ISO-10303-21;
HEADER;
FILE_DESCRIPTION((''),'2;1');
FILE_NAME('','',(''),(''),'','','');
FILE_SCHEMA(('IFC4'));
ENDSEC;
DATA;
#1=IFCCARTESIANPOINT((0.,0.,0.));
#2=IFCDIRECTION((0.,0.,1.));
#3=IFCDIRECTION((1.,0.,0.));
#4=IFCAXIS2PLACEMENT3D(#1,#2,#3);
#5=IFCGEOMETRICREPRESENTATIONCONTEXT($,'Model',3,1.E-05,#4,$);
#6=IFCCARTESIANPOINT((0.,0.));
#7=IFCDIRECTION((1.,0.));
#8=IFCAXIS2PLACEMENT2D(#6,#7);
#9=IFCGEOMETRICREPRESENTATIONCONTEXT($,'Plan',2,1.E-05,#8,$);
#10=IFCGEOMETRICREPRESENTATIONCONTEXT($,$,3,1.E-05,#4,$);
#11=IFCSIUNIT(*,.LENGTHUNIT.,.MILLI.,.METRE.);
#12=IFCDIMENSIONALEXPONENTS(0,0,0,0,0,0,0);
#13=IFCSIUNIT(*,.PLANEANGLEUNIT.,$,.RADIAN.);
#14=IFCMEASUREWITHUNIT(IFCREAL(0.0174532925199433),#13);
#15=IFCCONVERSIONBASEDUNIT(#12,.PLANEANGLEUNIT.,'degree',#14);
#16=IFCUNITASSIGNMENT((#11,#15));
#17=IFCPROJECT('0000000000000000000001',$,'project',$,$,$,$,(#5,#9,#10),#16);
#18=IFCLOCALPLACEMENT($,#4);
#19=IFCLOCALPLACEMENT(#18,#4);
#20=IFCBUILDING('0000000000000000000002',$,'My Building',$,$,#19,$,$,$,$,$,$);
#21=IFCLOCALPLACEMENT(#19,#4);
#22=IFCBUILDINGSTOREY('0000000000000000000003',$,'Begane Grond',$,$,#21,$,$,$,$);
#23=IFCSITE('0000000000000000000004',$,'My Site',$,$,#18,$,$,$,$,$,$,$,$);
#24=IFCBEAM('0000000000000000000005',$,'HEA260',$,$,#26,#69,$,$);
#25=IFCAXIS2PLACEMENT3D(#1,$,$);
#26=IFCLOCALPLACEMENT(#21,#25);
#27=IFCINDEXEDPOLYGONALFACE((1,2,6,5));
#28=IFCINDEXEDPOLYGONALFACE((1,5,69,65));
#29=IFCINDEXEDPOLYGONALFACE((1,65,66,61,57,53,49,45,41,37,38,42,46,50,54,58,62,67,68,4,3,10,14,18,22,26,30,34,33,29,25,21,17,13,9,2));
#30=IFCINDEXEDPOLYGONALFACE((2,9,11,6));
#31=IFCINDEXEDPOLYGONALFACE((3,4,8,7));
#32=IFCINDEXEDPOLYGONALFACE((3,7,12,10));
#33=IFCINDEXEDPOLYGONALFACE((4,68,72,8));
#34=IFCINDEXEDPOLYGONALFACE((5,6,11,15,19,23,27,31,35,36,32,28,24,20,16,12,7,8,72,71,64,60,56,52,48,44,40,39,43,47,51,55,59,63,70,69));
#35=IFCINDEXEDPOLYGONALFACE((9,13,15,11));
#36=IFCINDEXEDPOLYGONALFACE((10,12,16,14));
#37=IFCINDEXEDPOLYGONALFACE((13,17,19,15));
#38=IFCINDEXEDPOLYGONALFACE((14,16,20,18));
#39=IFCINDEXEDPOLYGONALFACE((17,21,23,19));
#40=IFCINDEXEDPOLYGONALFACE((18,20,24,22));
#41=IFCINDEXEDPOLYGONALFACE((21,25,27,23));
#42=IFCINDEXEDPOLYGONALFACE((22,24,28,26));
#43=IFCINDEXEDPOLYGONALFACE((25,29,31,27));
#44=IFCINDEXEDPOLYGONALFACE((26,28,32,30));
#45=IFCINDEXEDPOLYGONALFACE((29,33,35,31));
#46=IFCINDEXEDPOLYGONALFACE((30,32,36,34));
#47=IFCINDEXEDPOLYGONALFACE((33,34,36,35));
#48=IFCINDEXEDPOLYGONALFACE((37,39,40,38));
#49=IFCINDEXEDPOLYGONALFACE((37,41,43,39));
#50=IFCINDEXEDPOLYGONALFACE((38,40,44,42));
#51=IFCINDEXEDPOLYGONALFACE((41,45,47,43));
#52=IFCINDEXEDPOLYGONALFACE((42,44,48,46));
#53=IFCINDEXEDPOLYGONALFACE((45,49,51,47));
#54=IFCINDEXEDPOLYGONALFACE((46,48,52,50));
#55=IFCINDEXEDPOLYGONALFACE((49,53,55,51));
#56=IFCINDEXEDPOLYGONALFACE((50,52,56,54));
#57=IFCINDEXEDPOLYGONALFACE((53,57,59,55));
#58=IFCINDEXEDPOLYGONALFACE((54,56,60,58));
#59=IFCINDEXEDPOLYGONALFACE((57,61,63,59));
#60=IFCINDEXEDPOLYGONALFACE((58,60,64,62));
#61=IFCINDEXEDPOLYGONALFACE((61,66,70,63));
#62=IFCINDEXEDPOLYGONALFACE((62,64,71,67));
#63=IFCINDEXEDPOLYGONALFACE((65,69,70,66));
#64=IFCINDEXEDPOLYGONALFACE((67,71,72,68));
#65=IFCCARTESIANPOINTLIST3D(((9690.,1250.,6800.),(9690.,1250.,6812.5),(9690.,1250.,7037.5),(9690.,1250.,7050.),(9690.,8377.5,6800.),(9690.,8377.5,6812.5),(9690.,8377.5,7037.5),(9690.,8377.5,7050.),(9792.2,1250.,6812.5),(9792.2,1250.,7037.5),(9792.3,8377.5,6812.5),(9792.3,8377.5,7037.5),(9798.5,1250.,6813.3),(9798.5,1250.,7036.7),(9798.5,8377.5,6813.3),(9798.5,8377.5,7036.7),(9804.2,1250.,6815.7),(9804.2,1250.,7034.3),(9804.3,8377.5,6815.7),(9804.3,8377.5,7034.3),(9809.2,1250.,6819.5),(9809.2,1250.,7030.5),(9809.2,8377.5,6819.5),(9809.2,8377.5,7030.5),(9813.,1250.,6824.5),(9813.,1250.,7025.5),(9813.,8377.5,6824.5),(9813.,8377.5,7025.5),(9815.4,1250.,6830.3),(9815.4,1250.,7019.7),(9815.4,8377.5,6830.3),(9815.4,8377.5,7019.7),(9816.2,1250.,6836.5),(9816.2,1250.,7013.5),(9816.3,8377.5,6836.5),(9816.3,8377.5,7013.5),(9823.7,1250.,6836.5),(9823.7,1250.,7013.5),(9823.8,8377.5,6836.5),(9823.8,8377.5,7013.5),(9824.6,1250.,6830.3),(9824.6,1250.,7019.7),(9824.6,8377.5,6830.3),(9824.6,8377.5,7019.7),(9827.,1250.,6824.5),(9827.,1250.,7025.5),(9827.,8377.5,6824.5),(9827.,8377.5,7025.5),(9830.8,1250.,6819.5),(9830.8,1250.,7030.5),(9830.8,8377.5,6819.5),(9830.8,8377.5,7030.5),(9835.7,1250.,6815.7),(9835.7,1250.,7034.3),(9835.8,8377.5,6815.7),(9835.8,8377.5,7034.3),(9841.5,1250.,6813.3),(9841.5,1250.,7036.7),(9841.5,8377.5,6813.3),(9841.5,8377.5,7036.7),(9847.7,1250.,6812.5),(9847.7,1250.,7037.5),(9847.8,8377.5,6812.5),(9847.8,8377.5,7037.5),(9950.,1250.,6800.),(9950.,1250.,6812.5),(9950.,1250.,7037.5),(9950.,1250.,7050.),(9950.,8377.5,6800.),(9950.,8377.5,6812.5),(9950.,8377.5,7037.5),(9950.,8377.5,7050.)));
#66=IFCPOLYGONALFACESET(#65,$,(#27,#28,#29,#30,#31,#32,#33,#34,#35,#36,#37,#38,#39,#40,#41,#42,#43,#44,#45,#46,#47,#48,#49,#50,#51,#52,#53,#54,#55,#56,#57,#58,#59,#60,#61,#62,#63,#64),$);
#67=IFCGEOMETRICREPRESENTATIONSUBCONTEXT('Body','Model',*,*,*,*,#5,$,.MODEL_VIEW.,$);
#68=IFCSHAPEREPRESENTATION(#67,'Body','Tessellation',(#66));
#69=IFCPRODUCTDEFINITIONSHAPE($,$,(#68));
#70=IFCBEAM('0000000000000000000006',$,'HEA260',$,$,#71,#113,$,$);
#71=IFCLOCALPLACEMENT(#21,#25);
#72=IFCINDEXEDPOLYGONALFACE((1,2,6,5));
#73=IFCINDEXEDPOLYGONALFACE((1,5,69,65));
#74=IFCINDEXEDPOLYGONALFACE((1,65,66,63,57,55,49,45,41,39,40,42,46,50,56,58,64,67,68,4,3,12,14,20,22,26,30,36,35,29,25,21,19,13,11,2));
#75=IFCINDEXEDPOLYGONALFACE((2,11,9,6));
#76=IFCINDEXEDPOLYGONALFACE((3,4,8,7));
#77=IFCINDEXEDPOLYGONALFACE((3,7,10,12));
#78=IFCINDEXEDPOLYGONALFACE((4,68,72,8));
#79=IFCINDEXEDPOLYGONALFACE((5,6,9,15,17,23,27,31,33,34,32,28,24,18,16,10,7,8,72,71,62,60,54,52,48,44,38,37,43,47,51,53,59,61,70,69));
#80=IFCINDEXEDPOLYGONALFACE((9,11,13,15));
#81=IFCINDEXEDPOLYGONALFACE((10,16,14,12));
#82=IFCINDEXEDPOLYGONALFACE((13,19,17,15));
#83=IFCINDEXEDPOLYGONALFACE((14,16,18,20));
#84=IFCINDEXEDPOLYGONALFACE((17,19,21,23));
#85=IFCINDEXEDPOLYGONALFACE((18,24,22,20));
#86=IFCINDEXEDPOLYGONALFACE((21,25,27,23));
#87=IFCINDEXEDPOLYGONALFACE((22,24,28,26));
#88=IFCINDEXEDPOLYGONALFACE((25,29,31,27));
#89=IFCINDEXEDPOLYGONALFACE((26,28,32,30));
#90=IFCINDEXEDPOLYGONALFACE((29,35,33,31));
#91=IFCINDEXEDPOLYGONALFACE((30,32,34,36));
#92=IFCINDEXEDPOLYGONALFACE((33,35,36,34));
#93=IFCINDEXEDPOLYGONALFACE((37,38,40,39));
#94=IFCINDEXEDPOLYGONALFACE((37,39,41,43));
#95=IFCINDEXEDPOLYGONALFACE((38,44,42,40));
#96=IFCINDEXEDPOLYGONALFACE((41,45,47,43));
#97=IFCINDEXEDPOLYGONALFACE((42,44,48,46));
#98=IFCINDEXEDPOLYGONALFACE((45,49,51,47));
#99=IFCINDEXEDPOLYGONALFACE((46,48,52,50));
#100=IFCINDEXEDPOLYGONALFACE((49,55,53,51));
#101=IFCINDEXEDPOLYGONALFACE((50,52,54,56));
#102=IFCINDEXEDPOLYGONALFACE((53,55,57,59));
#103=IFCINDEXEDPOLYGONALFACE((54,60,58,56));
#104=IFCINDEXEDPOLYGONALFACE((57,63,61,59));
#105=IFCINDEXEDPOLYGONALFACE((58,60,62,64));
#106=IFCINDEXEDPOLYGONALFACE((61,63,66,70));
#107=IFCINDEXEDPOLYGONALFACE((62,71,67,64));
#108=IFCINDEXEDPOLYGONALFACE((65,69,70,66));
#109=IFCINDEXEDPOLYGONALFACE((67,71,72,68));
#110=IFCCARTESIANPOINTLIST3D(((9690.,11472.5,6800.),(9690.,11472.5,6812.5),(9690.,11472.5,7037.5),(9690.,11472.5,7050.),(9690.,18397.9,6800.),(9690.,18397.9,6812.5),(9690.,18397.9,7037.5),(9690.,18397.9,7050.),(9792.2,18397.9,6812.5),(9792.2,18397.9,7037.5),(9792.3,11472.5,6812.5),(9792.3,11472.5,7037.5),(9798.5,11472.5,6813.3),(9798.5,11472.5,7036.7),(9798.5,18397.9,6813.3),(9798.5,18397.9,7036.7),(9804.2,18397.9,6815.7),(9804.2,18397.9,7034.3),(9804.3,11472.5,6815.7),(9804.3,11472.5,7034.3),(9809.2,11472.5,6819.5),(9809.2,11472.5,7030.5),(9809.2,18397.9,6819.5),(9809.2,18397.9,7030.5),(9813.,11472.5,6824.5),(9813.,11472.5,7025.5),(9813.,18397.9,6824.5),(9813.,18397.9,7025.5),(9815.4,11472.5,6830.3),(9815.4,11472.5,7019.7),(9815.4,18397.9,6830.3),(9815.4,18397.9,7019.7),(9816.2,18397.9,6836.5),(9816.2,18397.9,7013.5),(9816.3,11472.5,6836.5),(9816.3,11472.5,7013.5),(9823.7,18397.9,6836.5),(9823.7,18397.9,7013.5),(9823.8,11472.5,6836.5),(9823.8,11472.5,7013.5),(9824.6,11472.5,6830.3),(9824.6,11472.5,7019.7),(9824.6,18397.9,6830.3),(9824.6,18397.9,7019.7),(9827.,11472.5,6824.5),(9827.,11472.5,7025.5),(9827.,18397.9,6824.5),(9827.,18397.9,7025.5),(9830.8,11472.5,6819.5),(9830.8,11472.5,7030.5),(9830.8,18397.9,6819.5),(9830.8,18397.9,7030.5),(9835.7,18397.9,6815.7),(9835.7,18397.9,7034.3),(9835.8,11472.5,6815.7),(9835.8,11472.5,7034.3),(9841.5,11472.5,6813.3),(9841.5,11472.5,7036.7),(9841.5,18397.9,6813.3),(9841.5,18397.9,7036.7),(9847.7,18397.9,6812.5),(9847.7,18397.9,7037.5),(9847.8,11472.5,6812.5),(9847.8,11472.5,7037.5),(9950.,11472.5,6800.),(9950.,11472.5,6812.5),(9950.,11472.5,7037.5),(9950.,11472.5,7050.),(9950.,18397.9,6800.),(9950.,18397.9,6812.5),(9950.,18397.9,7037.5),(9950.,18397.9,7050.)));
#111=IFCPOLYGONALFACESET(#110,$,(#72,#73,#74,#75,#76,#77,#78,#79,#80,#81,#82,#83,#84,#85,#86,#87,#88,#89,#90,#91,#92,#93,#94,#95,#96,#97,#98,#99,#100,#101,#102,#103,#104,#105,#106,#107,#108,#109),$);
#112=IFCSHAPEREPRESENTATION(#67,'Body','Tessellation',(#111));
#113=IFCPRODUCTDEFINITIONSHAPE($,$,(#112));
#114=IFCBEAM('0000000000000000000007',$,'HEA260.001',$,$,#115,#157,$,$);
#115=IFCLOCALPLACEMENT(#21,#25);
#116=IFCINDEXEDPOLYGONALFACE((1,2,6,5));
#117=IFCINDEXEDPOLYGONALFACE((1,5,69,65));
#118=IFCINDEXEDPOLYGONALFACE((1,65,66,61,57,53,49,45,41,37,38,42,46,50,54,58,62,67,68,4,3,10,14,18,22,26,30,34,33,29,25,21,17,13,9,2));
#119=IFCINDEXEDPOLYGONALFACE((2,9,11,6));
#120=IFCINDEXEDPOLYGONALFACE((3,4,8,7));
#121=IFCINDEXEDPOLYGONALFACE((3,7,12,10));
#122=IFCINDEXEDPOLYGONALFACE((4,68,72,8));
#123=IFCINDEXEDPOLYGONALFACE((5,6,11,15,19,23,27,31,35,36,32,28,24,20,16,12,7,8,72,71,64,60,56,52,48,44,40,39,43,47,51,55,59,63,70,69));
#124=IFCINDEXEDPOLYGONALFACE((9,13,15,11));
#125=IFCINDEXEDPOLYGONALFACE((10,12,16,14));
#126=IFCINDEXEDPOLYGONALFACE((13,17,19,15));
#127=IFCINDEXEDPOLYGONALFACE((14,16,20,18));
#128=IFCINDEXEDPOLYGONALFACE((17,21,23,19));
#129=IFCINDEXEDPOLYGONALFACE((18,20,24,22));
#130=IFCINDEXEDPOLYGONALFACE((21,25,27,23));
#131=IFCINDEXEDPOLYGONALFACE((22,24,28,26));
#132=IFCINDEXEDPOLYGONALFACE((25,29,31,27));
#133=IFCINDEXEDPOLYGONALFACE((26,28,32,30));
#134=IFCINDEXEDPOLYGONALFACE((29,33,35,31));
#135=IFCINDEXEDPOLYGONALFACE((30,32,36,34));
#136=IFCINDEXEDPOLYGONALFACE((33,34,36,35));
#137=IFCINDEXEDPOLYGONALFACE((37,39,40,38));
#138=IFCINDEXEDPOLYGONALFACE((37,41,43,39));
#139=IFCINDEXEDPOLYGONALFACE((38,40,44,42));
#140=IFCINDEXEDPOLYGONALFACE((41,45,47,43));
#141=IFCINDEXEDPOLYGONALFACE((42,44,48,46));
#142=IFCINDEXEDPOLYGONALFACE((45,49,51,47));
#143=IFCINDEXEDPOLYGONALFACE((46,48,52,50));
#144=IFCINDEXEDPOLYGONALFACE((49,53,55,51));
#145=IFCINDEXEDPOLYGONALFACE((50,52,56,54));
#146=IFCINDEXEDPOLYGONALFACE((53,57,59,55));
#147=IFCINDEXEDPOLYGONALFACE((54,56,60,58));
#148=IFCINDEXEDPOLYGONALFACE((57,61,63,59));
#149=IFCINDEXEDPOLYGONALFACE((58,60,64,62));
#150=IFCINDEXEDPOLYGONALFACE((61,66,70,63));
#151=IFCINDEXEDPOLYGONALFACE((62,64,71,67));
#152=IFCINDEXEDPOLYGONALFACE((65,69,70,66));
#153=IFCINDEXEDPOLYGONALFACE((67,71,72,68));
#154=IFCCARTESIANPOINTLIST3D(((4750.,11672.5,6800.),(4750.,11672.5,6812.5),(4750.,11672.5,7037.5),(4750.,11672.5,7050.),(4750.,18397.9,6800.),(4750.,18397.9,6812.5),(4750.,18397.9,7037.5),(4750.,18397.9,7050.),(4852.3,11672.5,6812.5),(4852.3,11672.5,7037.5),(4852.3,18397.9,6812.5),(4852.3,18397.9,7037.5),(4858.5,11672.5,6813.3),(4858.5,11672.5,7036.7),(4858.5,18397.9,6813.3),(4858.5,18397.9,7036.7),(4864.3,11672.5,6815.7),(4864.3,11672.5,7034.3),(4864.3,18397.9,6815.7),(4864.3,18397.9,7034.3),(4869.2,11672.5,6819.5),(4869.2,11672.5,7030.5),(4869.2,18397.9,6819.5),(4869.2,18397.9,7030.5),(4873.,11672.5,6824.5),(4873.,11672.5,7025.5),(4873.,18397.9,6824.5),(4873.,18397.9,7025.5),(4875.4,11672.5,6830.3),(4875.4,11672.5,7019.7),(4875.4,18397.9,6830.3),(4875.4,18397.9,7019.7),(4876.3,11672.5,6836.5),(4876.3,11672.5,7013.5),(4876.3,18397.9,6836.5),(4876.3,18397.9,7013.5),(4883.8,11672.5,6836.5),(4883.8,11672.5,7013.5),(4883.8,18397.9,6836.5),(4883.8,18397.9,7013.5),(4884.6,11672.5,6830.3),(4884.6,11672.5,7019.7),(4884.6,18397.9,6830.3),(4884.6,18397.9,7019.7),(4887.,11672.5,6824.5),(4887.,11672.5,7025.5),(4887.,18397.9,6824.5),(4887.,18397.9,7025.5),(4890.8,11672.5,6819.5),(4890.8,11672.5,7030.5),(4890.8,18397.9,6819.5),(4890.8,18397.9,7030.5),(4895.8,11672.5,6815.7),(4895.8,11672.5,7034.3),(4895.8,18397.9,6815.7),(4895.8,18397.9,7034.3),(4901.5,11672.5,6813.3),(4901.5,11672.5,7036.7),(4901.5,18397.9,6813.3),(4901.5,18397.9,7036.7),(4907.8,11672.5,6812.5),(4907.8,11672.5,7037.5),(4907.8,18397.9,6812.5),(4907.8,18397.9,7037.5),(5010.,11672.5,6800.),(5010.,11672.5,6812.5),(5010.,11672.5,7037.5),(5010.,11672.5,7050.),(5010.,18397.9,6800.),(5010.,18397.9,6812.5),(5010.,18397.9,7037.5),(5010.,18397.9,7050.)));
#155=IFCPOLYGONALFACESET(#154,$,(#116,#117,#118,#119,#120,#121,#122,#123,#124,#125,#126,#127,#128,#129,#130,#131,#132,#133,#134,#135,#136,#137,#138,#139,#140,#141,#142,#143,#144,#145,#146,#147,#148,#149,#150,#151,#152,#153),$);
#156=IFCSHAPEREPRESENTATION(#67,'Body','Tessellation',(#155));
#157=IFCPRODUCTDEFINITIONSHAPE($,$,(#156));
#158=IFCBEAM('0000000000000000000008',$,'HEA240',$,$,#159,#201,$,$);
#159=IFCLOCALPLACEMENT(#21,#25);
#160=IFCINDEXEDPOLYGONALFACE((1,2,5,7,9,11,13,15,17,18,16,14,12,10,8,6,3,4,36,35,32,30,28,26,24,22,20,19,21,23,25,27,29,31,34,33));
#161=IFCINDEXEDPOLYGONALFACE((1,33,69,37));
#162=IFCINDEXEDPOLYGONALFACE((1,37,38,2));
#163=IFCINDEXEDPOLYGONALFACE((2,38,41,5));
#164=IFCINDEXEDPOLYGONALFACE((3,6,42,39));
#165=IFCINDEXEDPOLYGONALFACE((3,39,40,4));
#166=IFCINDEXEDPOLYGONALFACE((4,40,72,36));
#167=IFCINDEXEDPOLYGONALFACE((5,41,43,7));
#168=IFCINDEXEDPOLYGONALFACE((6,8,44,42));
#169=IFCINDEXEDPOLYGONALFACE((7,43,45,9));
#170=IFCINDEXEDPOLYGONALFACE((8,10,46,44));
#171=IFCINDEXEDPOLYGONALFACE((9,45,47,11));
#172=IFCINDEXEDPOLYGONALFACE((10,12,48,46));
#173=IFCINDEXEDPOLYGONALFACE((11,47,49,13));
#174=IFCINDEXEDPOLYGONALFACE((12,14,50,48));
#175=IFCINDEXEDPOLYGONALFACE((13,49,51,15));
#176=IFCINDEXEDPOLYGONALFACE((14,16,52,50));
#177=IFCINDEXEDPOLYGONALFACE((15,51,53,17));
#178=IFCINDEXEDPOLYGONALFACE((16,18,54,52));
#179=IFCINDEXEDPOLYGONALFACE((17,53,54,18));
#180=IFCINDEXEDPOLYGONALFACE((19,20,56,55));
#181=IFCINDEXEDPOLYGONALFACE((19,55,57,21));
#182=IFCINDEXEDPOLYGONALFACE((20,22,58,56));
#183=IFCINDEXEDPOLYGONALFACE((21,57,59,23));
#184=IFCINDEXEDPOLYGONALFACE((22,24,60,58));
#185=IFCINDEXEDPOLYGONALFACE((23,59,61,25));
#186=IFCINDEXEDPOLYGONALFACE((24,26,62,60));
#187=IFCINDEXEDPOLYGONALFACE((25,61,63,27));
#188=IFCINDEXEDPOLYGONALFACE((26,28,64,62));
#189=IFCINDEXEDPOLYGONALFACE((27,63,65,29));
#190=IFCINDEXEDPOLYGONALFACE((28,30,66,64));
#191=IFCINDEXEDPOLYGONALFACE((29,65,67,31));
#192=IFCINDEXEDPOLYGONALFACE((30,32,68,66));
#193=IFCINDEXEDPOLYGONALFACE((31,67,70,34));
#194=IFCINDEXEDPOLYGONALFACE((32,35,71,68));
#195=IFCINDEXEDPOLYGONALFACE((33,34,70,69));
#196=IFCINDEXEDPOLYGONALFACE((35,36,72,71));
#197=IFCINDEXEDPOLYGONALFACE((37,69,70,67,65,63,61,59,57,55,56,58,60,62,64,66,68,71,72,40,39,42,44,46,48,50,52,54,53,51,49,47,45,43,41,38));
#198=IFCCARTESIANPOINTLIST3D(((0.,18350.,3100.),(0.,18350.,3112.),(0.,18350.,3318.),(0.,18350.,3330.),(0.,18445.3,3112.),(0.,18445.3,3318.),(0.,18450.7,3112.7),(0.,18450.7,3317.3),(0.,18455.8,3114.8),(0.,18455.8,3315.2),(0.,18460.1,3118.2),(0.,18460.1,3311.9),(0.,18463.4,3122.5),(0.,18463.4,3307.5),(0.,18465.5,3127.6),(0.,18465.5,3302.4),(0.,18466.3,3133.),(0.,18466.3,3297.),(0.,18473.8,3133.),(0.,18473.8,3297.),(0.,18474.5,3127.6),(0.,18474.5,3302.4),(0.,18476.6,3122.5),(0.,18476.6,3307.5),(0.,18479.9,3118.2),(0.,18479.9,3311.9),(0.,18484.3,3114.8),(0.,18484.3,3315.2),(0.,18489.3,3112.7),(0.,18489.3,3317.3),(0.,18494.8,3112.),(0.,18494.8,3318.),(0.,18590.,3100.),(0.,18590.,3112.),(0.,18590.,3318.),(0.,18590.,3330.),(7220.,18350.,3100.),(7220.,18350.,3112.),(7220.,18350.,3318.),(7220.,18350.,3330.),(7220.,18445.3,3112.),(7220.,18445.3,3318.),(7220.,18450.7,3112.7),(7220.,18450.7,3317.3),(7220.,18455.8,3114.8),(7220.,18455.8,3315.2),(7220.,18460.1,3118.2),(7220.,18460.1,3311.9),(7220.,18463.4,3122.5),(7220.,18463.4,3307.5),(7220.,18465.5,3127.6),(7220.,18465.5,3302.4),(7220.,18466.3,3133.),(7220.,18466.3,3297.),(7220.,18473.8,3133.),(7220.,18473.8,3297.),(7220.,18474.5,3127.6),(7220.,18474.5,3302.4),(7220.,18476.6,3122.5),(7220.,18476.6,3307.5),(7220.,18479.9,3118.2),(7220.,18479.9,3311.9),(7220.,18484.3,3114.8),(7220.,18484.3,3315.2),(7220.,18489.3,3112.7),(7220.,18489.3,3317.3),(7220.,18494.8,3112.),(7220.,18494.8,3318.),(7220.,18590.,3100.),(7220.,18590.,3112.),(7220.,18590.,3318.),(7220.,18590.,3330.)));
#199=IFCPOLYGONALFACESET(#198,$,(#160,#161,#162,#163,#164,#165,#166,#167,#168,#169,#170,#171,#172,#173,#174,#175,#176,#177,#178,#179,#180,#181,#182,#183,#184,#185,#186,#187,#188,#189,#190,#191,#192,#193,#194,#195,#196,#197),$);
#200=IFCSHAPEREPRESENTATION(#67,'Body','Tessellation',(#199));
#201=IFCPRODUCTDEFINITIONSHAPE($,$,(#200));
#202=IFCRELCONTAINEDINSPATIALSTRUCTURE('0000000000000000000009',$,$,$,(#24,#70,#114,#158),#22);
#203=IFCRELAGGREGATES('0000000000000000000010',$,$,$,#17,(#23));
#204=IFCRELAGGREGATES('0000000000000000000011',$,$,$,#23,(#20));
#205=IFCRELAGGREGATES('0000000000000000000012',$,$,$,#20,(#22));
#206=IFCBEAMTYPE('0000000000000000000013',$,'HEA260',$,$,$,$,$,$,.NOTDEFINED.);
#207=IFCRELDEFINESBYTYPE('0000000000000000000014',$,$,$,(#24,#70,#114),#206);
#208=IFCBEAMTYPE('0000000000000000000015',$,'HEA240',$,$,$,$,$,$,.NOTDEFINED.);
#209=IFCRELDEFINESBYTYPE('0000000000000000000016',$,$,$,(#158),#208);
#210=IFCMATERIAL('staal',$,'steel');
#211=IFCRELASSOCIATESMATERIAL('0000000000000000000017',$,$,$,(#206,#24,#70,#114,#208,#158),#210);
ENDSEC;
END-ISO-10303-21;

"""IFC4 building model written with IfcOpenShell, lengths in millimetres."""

from ifc_helpers import new_model, entity, si_unit, converted_unit, frame, origin_with_axes, origin_2d_with_axis, place, context, subcontext, project, spatial, i_section, extrude, material, material_profile, profile_set, profile_usage, type_object, element, save


model = new_model("IFC4")

# Units and contexts
model_context = context("Model", 3, precision=1e-05, world=origin_with_axes())
plan_context = context("Plan", 2, precision=1e-05, world=origin_2d_with_axis())
context_of_model = context(None, 3, precision=1e-05, world=origin_with_axes())
body_context = subcontext(model_context, "Body", "Model", "MODEL_VIEW")
ifc_project = project(units=[si_unit("LENGTHUNIT", "METRE", prefix="MILLI"), converted_unit("PLANEANGLEUNIT", "degree", entity("IfcReal", 0.0174532925199433), si_unit("PLANEANGLEUNIT", "RADIAN"), dimensions=[0, 0, 0, 0, 0, 0, 0])], contexts=[model_context, plan_context, context_of_model])

# Site, building, storey
site_placement = place(None, origin_with_axes())
site = spatial("IfcSite", under=ifc_project, at=site_placement, Name="My Site")
building_placement = place(site_placement, origin_with_axes())
building = spatial("IfcBuilding", under=site, at=building_placement, Name="My Building")
storey_placement = place(building_placement, origin_with_axes())
storey = spatial("IfcBuildingStorey", under=building, at=storey_placement, Name="Begane Grond")

# Shared definitions
ifc_material = material(Name="staal", Category="steel")

# Beams
ifc_material_profile_1 = material_profile(ifc_material, i_section(OverallWidth=260.0, OverallDepth=250.0, WebThickness=7.5, FlangeThickness=12.5, FilletRadius=24.0))
ifc_profile_set_1 = profile_set([ifc_material_profile_1], Name="HEA260")
beam_type_1 = type_object("IfcBeamType", Name="HEA260", PredefinedType="NOTDEFINED", material=ifc_profile_set_1)
ifc_profile_usage_1 = profile_usage(ifc_profile_set_1)
beam_1_placement = place(storey_placement, frame((9820.0, 1250.0, 6925.0), z_axis=(0.0, 1.0, 0.0), x_axis=(-1.0, 0.0, 0.0)))
element("IfcBeam", 1, at=beam_1_placement, inside=storey, type_object=beam_type_1, material=ifc_profile_usage_1, Name="HEA260", context=body_context, shape_type="SweptSolid", body=[
    extrude(i_section(OverallWidth=260.0, OverallDepth=250.0, WebThickness=7.5, FlangeThickness=12.5, FilletRadius=24.0), origin_with_axes(), (0.0, 0.0, 1.0), 7127.5),
])
ifc_profile_usage_2 = profile_usage(ifc_profile_set_1)
beam_2_placement = place(storey_placement, frame((9820.0, 18397.9, 6925.0), z_axis=(0.0, -1.0, 0.0), x_axis=(1.0, 0.0, 0.0)))
element("IfcBeam", 2, at=beam_2_placement, inside=storey, type_object=beam_type_1, material=ifc_profile_usage_2, Name="HEA260", context=body_context, shape_type="SweptSolid", body=[
    extrude(i_section(OverallWidth=260.0, OverallDepth=250.0, WebThickness=7.5, FlangeThickness=12.5, FilletRadius=24.0), origin_with_axes(), (0.0, 0.0, 1.0), 6925.4),
])
ifc_profile_usage_3 = profile_usage(ifc_profile_set_1)
beam_3_placement = place(storey_placement, frame((4880.0, 18397.9, 6925.0), z_axis=(0.0, -1.0, 0.0), x_axis=(1.0, 0.0, 0.0)))
element("IfcBeam", 3, at=beam_3_placement, inside=storey, type_object=beam_type_1, material=ifc_profile_usage_3, Name="HEA260.001", context=body_context, shape_type="SweptSolid", body=[
    extrude(i_section(OverallWidth=260.0, OverallDepth=250.0, WebThickness=7.5, FlangeThickness=12.5, FilletRadius=24.0), origin_with_axes(), (0.0, 0.0, 1.0), 6725.4),
])
ifc_material_profile_2 = material_profile(ifc_material, i_section(OverallWidth=240.0, OverallDepth=230.0, WebThickness=7.5, FlangeThickness=12.0, FilletRadius=21.0))
ifc_profile_set_2 = profile_set([ifc_material_profile_2], Name="HEA240")
ifc_profile_usage_4 = profile_usage(ifc_profile_set_2, cardinal=5)
beam_type_2 = type_object("IfcBeamType", Name="HEA240", PredefinedType="NOTDEFINED", material=ifc_profile_set_2)
beam_4_placement = place(storey_placement, frame((0.0, 18470.0, 3215.0), z_axis=(1.0, 0.0, 0.0), x_axis=(0.0, 1.0, 0.0)))
element("IfcBeam", 4, at=beam_4_placement, inside=storey, type_object=beam_type_2, material=ifc_profile_usage_4, Name="HEA240", context=body_context, shape_type="SweptSolid", body=[
    extrude(i_section(OverallWidth=240.0, OverallDepth=230.0, WebThickness=7.5, FlangeThickness=12.0, FilletRadius=21.0), origin_with_axes(), (0.0, 0.0, 1.0), 7220.0),
])

save(model, "model.ifc")
